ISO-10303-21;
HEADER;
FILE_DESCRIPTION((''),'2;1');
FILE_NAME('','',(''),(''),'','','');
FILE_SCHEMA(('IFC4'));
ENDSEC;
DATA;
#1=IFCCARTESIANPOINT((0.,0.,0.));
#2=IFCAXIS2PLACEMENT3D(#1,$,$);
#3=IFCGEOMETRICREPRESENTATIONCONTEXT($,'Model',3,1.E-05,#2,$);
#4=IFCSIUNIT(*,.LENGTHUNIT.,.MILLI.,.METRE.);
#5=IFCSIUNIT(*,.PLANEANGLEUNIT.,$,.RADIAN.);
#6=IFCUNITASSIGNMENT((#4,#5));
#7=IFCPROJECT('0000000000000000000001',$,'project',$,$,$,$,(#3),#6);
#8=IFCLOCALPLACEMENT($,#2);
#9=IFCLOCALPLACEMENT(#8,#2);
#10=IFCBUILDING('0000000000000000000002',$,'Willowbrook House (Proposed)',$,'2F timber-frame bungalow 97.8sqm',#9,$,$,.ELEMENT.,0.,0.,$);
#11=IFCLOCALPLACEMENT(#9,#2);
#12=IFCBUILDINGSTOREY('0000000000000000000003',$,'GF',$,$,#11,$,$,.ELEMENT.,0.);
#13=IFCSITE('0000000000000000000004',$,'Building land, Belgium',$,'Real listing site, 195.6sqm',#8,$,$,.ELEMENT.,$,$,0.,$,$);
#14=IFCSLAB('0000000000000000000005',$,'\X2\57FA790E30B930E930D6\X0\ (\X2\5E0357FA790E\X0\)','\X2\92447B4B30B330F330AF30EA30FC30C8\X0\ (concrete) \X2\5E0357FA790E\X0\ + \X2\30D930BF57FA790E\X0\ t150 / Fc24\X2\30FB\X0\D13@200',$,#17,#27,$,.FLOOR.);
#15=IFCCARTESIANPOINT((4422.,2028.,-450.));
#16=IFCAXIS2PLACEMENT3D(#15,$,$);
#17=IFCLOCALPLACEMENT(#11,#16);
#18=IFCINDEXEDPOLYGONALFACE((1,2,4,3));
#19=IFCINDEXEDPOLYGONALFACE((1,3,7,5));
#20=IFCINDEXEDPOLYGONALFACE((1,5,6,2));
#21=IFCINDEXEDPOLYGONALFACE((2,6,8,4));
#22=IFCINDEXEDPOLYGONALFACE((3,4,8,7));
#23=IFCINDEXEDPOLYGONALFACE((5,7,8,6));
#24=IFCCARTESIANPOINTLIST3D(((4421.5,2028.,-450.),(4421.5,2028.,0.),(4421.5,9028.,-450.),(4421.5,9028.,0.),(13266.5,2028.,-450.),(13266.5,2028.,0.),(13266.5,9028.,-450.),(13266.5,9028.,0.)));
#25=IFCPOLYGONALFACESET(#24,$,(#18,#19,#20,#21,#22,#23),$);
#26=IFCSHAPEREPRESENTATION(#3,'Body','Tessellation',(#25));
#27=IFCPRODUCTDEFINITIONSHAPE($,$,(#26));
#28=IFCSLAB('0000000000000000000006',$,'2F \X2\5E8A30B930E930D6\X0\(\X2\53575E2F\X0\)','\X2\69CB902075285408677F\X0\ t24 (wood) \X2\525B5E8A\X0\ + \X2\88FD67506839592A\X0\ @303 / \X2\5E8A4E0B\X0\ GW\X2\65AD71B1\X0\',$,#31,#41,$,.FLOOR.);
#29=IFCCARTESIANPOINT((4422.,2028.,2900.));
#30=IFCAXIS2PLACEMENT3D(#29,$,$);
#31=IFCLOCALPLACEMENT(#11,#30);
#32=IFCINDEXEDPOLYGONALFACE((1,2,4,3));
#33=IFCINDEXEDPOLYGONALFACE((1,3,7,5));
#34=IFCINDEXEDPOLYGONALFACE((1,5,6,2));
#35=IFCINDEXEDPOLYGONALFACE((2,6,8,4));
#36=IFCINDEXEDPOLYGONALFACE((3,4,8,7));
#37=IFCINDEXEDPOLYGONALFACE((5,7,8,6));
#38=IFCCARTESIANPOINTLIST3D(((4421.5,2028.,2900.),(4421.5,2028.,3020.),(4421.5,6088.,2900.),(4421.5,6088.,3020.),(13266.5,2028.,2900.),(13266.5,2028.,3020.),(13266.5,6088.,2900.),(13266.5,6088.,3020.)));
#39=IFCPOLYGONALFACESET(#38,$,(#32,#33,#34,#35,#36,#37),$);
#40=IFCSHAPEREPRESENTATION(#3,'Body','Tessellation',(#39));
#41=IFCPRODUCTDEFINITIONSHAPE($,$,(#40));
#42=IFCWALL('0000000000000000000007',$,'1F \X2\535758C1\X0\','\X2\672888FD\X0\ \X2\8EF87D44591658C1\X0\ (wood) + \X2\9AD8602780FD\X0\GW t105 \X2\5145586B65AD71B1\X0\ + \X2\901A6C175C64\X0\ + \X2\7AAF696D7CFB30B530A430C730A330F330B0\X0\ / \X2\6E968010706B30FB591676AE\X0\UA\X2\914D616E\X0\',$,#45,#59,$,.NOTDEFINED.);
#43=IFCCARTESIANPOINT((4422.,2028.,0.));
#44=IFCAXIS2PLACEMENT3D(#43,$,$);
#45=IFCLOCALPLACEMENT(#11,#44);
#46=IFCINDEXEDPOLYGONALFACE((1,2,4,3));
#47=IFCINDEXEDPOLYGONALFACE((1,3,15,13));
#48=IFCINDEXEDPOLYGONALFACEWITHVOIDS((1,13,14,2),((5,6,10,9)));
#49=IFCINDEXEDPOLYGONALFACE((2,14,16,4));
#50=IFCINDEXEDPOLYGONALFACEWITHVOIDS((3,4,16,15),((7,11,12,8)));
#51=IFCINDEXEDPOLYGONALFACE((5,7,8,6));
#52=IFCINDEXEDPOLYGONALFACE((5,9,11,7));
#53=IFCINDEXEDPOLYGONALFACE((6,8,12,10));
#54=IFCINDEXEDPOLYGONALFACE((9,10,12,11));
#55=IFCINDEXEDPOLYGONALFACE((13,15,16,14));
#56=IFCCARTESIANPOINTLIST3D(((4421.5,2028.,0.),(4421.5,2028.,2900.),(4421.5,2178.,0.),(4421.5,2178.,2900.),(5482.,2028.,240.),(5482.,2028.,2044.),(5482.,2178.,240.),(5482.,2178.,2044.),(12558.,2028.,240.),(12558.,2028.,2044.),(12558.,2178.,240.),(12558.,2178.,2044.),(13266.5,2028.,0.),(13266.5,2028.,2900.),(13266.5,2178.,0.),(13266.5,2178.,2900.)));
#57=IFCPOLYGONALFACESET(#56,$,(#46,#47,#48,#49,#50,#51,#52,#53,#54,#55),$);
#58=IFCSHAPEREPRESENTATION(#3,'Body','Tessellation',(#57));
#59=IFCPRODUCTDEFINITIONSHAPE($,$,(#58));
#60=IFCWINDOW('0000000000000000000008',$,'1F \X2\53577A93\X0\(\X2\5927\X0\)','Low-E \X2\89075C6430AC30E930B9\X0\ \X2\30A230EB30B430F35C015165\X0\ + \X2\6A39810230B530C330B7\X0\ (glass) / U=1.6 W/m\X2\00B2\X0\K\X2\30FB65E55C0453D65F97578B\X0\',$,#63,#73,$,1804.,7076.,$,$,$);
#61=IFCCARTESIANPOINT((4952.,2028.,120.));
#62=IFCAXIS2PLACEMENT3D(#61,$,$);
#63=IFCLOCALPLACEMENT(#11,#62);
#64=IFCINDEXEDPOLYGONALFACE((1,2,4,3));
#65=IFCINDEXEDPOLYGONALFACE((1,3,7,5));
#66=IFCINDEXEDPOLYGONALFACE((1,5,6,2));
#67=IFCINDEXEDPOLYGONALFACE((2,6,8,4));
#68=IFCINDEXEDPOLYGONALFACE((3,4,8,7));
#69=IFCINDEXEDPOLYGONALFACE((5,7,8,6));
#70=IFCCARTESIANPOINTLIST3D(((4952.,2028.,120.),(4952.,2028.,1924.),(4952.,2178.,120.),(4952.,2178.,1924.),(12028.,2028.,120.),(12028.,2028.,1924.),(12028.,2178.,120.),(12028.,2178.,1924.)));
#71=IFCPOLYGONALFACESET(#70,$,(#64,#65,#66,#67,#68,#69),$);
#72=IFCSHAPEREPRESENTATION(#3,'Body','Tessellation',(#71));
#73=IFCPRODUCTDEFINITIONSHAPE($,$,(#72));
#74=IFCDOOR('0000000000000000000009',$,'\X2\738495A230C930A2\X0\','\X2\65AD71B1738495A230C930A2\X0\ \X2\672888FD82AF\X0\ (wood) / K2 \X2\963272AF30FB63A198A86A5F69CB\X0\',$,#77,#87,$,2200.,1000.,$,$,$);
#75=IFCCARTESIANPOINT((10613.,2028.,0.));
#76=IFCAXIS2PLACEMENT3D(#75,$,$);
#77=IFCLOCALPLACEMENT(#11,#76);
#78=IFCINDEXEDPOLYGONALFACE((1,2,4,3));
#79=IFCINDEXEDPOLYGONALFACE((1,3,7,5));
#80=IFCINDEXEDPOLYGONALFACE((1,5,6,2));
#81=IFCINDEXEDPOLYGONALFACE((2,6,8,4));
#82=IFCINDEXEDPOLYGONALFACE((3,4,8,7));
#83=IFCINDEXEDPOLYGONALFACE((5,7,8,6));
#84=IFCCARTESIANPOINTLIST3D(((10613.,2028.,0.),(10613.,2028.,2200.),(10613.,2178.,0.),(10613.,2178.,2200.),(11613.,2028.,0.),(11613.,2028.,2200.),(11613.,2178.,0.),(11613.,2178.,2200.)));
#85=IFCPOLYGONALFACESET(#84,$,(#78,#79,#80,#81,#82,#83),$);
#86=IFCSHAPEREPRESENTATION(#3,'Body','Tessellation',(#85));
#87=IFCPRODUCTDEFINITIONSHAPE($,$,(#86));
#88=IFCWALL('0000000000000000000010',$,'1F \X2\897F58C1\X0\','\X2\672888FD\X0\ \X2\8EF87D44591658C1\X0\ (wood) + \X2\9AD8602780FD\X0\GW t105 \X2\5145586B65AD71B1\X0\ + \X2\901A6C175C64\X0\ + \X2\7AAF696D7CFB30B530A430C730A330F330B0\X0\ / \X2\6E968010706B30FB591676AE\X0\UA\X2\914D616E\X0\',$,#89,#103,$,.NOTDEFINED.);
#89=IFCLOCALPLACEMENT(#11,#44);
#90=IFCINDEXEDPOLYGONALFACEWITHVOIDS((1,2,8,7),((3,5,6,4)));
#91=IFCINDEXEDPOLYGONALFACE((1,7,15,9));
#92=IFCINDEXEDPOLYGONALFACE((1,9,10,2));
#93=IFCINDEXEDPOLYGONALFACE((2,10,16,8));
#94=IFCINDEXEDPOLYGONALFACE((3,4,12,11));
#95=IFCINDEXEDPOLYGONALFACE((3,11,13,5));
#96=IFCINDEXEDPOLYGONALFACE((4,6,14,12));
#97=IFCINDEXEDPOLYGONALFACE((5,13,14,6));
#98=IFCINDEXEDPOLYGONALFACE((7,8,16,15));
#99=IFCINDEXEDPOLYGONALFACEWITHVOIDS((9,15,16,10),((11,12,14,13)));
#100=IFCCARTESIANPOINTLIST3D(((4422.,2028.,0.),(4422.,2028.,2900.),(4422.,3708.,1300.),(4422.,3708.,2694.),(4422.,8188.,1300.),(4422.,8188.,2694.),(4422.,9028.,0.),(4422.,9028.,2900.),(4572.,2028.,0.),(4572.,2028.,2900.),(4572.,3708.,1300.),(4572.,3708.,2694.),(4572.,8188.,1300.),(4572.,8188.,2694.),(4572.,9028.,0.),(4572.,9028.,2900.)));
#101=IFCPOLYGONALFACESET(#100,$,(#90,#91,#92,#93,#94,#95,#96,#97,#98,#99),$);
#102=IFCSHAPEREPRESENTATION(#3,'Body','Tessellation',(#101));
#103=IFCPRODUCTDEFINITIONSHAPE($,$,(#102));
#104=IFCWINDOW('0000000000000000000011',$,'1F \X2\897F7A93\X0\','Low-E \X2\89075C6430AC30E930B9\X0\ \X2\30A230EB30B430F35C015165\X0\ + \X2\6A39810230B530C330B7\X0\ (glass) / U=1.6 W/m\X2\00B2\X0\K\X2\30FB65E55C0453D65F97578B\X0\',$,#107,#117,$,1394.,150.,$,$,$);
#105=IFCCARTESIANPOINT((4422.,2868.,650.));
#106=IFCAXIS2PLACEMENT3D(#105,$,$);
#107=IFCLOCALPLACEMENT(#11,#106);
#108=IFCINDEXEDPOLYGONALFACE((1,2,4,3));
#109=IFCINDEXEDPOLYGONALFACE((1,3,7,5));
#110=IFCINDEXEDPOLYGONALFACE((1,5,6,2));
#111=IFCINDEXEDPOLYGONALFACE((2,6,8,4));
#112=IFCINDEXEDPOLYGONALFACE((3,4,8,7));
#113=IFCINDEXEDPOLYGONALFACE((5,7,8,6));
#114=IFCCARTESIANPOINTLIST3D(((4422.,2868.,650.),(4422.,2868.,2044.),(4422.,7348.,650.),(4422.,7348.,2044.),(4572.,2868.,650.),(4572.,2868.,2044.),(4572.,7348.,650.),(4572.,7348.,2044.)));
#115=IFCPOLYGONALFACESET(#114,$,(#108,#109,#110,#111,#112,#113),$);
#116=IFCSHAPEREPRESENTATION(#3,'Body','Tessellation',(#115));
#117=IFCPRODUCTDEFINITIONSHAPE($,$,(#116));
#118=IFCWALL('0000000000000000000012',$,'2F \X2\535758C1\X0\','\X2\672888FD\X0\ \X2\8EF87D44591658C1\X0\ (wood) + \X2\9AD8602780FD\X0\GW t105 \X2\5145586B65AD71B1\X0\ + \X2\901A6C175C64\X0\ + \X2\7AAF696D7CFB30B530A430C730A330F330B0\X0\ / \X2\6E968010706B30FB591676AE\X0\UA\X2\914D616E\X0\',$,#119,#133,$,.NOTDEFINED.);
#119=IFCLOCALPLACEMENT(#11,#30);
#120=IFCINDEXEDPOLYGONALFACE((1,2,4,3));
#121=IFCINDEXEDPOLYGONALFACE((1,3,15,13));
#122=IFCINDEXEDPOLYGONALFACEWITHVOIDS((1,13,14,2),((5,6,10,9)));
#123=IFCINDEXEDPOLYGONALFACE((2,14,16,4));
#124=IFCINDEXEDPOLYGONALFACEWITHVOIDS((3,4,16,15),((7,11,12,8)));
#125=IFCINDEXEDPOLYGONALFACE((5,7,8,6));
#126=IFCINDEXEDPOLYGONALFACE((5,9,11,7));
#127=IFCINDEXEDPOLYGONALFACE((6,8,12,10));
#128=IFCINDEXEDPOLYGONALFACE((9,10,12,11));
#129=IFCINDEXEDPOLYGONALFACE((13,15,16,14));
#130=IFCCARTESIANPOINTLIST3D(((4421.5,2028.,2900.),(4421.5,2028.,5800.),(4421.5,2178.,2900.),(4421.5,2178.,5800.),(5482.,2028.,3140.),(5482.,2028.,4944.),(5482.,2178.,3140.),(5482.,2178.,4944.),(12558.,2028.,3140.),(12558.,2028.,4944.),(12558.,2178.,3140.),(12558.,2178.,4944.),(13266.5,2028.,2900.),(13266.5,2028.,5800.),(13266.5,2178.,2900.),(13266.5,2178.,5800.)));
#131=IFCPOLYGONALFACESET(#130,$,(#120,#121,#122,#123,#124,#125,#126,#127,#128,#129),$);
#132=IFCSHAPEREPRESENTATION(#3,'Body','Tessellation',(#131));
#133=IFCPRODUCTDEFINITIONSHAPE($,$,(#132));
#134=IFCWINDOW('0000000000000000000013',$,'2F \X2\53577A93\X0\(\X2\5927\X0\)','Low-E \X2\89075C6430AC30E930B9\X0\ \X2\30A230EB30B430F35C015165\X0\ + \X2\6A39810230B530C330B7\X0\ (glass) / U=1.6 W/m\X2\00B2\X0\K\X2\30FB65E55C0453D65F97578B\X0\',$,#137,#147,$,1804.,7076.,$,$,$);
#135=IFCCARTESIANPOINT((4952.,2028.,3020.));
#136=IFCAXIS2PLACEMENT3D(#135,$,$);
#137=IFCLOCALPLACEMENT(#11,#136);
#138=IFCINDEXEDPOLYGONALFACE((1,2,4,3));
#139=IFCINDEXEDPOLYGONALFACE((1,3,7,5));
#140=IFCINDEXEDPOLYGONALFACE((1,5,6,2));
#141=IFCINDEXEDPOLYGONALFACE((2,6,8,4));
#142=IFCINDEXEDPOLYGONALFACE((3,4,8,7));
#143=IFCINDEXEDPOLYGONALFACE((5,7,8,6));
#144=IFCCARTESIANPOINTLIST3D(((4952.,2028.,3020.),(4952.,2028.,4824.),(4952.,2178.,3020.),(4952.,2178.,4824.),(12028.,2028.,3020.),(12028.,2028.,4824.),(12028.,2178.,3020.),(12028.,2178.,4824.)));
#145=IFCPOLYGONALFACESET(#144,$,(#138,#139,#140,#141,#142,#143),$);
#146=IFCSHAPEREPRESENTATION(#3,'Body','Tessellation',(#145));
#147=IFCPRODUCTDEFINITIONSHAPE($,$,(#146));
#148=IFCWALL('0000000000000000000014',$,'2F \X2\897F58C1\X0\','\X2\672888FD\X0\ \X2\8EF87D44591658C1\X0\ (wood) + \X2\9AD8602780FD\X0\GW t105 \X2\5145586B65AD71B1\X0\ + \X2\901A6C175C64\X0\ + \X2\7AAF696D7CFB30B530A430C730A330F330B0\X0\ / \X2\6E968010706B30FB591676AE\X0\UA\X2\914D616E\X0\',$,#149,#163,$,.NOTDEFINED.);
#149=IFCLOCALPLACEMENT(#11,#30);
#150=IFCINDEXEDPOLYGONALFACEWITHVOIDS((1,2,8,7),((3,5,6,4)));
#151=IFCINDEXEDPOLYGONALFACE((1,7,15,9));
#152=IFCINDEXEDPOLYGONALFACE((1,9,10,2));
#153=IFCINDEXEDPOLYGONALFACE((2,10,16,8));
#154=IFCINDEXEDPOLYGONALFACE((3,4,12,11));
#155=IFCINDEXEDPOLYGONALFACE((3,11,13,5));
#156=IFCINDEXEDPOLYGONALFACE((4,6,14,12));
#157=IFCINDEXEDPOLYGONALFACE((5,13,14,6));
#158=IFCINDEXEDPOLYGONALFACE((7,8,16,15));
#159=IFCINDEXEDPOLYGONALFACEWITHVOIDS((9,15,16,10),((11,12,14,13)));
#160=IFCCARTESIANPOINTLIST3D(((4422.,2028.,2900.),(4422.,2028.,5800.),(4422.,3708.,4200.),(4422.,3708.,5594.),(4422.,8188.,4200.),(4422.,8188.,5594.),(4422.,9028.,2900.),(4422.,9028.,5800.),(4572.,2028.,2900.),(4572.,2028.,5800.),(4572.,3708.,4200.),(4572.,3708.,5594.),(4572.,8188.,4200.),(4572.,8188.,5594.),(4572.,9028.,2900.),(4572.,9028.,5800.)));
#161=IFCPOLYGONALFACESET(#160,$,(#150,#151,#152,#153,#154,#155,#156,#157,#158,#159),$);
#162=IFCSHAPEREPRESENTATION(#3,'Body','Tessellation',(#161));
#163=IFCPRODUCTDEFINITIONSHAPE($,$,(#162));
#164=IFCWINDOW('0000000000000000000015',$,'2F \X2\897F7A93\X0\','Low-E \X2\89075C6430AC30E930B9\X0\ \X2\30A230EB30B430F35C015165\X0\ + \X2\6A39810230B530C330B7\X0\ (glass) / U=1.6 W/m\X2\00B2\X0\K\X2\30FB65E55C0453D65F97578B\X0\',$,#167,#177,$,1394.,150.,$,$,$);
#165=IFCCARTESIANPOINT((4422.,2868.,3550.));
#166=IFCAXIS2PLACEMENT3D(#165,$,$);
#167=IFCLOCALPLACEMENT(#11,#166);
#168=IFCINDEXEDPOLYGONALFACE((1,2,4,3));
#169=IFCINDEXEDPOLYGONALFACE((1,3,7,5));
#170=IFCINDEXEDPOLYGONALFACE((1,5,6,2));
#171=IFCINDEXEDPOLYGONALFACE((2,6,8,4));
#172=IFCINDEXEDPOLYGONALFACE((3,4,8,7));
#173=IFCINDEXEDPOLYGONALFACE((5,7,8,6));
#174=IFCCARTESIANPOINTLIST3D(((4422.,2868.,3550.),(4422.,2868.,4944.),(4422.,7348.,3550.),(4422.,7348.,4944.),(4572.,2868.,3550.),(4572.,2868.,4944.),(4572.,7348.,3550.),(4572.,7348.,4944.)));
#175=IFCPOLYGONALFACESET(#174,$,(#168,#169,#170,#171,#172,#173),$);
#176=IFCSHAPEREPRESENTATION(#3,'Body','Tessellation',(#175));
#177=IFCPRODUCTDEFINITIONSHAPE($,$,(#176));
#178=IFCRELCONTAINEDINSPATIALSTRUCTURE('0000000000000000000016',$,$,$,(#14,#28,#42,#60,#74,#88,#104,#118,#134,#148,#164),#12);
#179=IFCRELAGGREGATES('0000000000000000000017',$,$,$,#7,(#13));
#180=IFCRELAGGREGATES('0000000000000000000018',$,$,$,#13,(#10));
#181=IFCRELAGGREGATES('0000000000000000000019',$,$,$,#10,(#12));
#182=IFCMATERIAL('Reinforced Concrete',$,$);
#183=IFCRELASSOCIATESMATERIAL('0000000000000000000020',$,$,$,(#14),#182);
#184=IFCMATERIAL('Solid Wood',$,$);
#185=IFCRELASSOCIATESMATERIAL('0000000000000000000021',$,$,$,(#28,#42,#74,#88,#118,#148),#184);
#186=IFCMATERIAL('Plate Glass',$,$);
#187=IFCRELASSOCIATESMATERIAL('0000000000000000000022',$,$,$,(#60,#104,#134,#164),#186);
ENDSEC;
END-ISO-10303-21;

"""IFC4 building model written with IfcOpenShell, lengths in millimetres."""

from ifc_helpers import new_model, si_unit, frame, frame_2d, origin, place, context, project, spatial, rectangle, extrude, material, element, fill, save


model = new_model("IFC4")

# Units and contexts
model_context = context("Model", 3, precision=1e-05, world=origin())
ifc_project = project(units=[si_unit("LENGTHUNIT", "METRE", prefix="MILLI"), si_unit("PLANEANGLEUNIT", "RADIAN")], contexts=[model_context])

# Site, building, storey
site_placement = place(None, origin())
site = spatial("IfcSite", under=ifc_project, at=site_placement, Name="Building land, Belgium", ObjectType="Real listing site, 195.6sqm", CompositionType="ELEMENT", RefElevation=0.0)
building_placement = place(site_placement, origin())
building = spatial("IfcBuilding", under=site, at=building_placement, Name="Willowbrook House (Proposed)", ObjectType="2F timber-frame bungalow 97.8sqm", CompositionType="ELEMENT", ElevationOfRefHeight=0.0, ElevationOfTerrain=0.0)
storey_placement = place(building_placement, origin())
storey = spatial("IfcBuildingStorey", under=building, at=storey_placement, Name="GF", CompositionType="ELEMENT", Elevation=0.0)

# Slabs
ifc_material_1 = material(Name="Reinforced Concrete")
slab_1_placement = place(storey_placement, frame((4422.0, 2028.0, -450.0)))
element("IfcSlab", 1, at=slab_1_placement, inside=storey, material=ifc_material_1, Name="基礎スラブ (布基礎)", Description="鉄筋コンクリート (concrete) 布基礎 + ベタ基礎 t150 / Fc24・D13@200", PredefinedType="FLOOR", context=model_context, shape_type="SweptSolid", body=[
    extrude(rectangle(XDim=8845.0, YDim=7000.0, at=frame_2d((4422.0, 3500.0))), frame((4422.0, 2028.0, -450.0)), (0.0, 0.0, 1.0), 450.0),
])
ifc_material_2 = material(Name="Solid Wood")
slab_2_placement = place(storey_placement, frame((4422.0, 2028.0, 2900.0)))
element("IfcSlab", 2, at=slab_2_placement, inside=storey, material=ifc_material_2, Name="2F 床スラブ(南帯)", Description="構造用合板 t24 (wood) 剛床 + 製材根太 @303 / 床下 GW断熱", PredefinedType="FLOOR", context=model_context, shape_type="SweptSolid", body=[
    extrude(rectangle(XDim=8845.0, YDim=4060.0, at=frame_2d((4422.0, 2030.0))), frame((4422.0, 2028.0, 2900.0)), (0.0, 0.0, 1.0), 120.0),
])

# Wall, openings, window, door
wall_1_placement = place(storey_placement, frame((4422.0, 2028.0, 0.0)))
wall_1 = element("IfcWall", 3, at=wall_1_placement, inside=storey, material=ifc_material_2, Name="1F 南壁", Description="木製 軸組外壁 (wood) + 高性能GW t105 充填断熱 + 通気層 + 窯業系サイディング / 準耐火・外皮UA配慮", PredefinedType="NOTDEFINED", context=model_context, shape_type="SweptSolid", body=[
    extrude(rectangle(XDim=8845.0, YDim=150.0, at=frame_2d((4422.0, 75.0))), frame((4422.0, 2028.0, 0.0)), (0.0, 0.0, 1.0), 2900.0),
])
opening_1_placement = place(storey_placement, frame((4952.0, 2028.0, 120.0)))
opening_1 = element("IfcOpeningElement", 4, at=opening_1_placement, cuts=wall_1, PredefinedType="NOTDEFINED", context=model_context, shape_type="SweptSolid", body=[
    extrude(rectangle(XDim=7076.0, YDim=150.0, at=frame_2d((3538.0, 75.0))), frame((4952.0, 2028.0, 120.0)), (0.0, 0.0, 1.0), 1804.0),
])
opening_2_placement = place(storey_placement, frame((10613.0, 2028.0, 0.0)))
opening_2 = element("IfcOpeningElement", 5, at=opening_2_placement, cuts=wall_1, PredefinedType="NOTDEFINED", context=model_context, shape_type="SweptSolid", body=[
    extrude(rectangle(XDim=1000.0, YDim=150.0, at=frame_2d((500.0, 75.0))), frame((10613.0, 2028.0, 0.0)), (0.0, 0.0, 1.0), 2200.0),
])
ifc_material_3 = material(Name="Plate Glass")
window_1_placement = place(storey_placement, frame((4952.0, 2028.0, 120.0)))
window_1 = element("IfcWindow", 6, at=window_1_placement, inside=storey, material=ifc_material_3, Name="1F 南窓(大)", Description="Low-E 複層ガラス アルゴン封入 + 樹脂サッシ (glass) / U=1.6 W/m²K・日射取得型", OverallHeight=1804.0, OverallWidth=7076.0, context=model_context, shape_type="SweptSolid", body=[
    extrude(rectangle(XDim=7076.0, YDim=150.0, at=frame_2d((3538.0, 75.0))), frame((4952.0, 2028.0, 120.0)), (0.0, 0.0, 1.0), 1804.0),
])
fill(opening_1, window_1)
door_placement = place(storey_placement, frame((10613.0, 2028.0, 0.0)))
door = element("IfcDoor", 7, at=door_placement, inside=storey, material=ifc_material_2, Name="玄関ドア", Description="断熱玄関ドア 木製芯 (wood) / K2 防犯・採風機構", OverallHeight=2200.0, OverallWidth=1000.0, context=model_context, shape_type="SweptSolid", body=[
    extrude(rectangle(XDim=1000.0, YDim=150.0, at=frame_2d((500.0, 75.0))), frame((10613.0, 2028.0, 0.0)), (0.0, 0.0, 1.0), 2200.0),
])
fill(opening_2, door)

# Wall, opening, window
wall_2_placement = place(storey_placement, frame((4422.0, 2028.0, 0.0)))
wall_2 = element("IfcWall", 8, at=wall_2_placement, inside=storey, material=ifc_material_2, Name="1F 西壁", Description="木製 軸組外壁 (wood) + 高性能GW t105 充填断熱 + 通気層 + 窯業系サイディング / 準耐火・外皮UA配慮", PredefinedType="NOTDEFINED", context=model_context, shape_type="SweptSolid", body=[
    extrude(rectangle(XDim=150.0, YDim=7000.0, at=frame_2d((75.0, 3500.0))), frame((4422.0, 2028.0, 0.0)), (0.0, 0.0, 1.0), 2900.0),
])
opening_3_placement = place(storey_placement, frame((4422.0, 2868.0, 650.0)))
opening_3 = element("IfcOpeningElement", 9, at=opening_3_placement, cuts=wall_2, PredefinedType="NOTDEFINED", context=model_context, shape_type="SweptSolid", body=[
    extrude(rectangle(XDim=150.0, YDim=4480.0, at=frame_2d((75.0, 2240.0))), frame((4422.0, 2868.0, 650.0)), (0.0, 0.0, 1.0), 1394.0),
])
window_2_placement = place(storey_placement, frame((4422.0, 2868.0, 650.0)))
window_2 = element("IfcWindow", 10, at=window_2_placement, inside=storey, material=ifc_material_3, Name="1F 西窓", Description="Low-E 複層ガラス アルゴン封入 + 樹脂サッシ (glass) / U=1.6 W/m²K・日射取得型", OverallHeight=1394.0, OverallWidth=150.0, context=model_context, shape_type="SweptSolid", body=[
    extrude(rectangle(XDim=150.0, YDim=4480.0, at=frame_2d((75.0, 2240.0))), frame((4422.0, 2868.0, 650.0)), (0.0, 0.0, 1.0), 1394.0),
])
fill(opening_3, window_2)

# Walls, openings, windows
wall_3_placement = place(storey_placement, frame((4422.0, 2028.0, 2900.0)))
wall_3 = element("IfcWall", 11, at=wall_3_placement, inside=storey, material=ifc_material_2, Name="2F 南壁", Description="木製 軸組外壁 (wood) + 高性能GW t105 充填断熱 + 通気層 + 窯業系サイディング / 準耐火・外皮UA配慮", PredefinedType="NOTDEFINED", context=model_context, shape_type="SweptSolid", body=[
    extrude(rectangle(XDim=8845.0, YDim=150.0, at=frame_2d((4422.0, 75.0))), frame((4422.0, 2028.0, 2900.0)), (0.0, 0.0, 1.0), 2900.0),
])
opening_4_placement = place(storey_placement, frame((4952.0, 2028.0, 3020.0)))
opening_4 = element("IfcOpeningElement", 12, at=opening_4_placement, cuts=wall_3, PredefinedType="NOTDEFINED", context=model_context, shape_type="SweptSolid", body=[
    extrude(rectangle(XDim=7076.0, YDim=150.0, at=frame_2d((3538.0, 75.0))), frame((4952.0, 2028.0, 3020.0)), (0.0, 0.0, 1.0), 1804.0),
])
window_3_placement = place(storey_placement, frame((4952.0, 2028.0, 3020.0)))
window_3 = element("IfcWindow", 13, at=window_3_placement, inside=storey, material=ifc_material_3, Name="2F 南窓(大)", Description="Low-E 複層ガラス アルゴン封入 + 樹脂サッシ (glass) / U=1.6 W/m²K・日射取得型", OverallHeight=1804.0, OverallWidth=7076.0, context=model_context, shape_type="SweptSolid", body=[
    extrude(rectangle(XDim=7076.0, YDim=150.0, at=frame_2d((3538.0, 75.0))), frame((4952.0, 2028.0, 3020.0)), (0.0, 0.0, 1.0), 1804.0),
])
fill(opening_4, window_3)
wall_4_placement = place(storey_placement, frame((4422.0, 2028.0, 2900.0)))
wall_4 = element("IfcWall", 14, at=wall_4_placement, inside=storey, material=ifc_material_2, Name="2F 西壁", Description="木製 軸組外壁 (wood) + 高性能GW t105 充填断熱 + 通気層 + 窯業系サイディング / 準耐火・外皮UA配慮", PredefinedType="NOTDEFINED", context=model_context, shape_type="SweptSolid", body=[
    extrude(rectangle(XDim=150.0, YDim=7000.0, at=frame_2d((75.0, 3500.0))), frame((4422.0, 2028.0, 2900.0)), (0.0, 0.0, 1.0), 2900.0),
])
opening_5_placement = place(storey_placement, frame((4422.0, 2868.0, 3550.0)))
opening_5 = element("IfcOpeningElement", 15, at=opening_5_placement, cuts=wall_4, PredefinedType="NOTDEFINED", context=model_context, shape_type="SweptSolid", body=[
    extrude(rectangle(XDim=150.0, YDim=4480.0, at=frame_2d((75.0, 2240.0))), frame((4422.0, 2868.0, 3550.0)), (0.0, 0.0, 1.0), 1394.0),
])
window_4_placement = place(storey_placement, frame((4422.0, 2868.0, 3550.0)))
window_4 = element("IfcWindow", 16, at=window_4_placement, inside=storey, material=ifc_material_3, Name="2F 西窓", Description="Low-E 複層ガラス アルゴン封入 + 樹脂サッシ (glass) / U=1.6 W/m²K・日射取得型", OverallHeight=1394.0, OverallWidth=150.0, context=model_context, shape_type="SweptSolid", body=[
    extrude(rectangle(XDim=150.0, YDim=4480.0, at=frame_2d((75.0, 2240.0))), frame((4422.0, 2868.0, 3550.0)), (0.0, 0.0, 1.0), 1394.0),
])
fill(opening_5, window_4)

save(model, "model.ifc")
